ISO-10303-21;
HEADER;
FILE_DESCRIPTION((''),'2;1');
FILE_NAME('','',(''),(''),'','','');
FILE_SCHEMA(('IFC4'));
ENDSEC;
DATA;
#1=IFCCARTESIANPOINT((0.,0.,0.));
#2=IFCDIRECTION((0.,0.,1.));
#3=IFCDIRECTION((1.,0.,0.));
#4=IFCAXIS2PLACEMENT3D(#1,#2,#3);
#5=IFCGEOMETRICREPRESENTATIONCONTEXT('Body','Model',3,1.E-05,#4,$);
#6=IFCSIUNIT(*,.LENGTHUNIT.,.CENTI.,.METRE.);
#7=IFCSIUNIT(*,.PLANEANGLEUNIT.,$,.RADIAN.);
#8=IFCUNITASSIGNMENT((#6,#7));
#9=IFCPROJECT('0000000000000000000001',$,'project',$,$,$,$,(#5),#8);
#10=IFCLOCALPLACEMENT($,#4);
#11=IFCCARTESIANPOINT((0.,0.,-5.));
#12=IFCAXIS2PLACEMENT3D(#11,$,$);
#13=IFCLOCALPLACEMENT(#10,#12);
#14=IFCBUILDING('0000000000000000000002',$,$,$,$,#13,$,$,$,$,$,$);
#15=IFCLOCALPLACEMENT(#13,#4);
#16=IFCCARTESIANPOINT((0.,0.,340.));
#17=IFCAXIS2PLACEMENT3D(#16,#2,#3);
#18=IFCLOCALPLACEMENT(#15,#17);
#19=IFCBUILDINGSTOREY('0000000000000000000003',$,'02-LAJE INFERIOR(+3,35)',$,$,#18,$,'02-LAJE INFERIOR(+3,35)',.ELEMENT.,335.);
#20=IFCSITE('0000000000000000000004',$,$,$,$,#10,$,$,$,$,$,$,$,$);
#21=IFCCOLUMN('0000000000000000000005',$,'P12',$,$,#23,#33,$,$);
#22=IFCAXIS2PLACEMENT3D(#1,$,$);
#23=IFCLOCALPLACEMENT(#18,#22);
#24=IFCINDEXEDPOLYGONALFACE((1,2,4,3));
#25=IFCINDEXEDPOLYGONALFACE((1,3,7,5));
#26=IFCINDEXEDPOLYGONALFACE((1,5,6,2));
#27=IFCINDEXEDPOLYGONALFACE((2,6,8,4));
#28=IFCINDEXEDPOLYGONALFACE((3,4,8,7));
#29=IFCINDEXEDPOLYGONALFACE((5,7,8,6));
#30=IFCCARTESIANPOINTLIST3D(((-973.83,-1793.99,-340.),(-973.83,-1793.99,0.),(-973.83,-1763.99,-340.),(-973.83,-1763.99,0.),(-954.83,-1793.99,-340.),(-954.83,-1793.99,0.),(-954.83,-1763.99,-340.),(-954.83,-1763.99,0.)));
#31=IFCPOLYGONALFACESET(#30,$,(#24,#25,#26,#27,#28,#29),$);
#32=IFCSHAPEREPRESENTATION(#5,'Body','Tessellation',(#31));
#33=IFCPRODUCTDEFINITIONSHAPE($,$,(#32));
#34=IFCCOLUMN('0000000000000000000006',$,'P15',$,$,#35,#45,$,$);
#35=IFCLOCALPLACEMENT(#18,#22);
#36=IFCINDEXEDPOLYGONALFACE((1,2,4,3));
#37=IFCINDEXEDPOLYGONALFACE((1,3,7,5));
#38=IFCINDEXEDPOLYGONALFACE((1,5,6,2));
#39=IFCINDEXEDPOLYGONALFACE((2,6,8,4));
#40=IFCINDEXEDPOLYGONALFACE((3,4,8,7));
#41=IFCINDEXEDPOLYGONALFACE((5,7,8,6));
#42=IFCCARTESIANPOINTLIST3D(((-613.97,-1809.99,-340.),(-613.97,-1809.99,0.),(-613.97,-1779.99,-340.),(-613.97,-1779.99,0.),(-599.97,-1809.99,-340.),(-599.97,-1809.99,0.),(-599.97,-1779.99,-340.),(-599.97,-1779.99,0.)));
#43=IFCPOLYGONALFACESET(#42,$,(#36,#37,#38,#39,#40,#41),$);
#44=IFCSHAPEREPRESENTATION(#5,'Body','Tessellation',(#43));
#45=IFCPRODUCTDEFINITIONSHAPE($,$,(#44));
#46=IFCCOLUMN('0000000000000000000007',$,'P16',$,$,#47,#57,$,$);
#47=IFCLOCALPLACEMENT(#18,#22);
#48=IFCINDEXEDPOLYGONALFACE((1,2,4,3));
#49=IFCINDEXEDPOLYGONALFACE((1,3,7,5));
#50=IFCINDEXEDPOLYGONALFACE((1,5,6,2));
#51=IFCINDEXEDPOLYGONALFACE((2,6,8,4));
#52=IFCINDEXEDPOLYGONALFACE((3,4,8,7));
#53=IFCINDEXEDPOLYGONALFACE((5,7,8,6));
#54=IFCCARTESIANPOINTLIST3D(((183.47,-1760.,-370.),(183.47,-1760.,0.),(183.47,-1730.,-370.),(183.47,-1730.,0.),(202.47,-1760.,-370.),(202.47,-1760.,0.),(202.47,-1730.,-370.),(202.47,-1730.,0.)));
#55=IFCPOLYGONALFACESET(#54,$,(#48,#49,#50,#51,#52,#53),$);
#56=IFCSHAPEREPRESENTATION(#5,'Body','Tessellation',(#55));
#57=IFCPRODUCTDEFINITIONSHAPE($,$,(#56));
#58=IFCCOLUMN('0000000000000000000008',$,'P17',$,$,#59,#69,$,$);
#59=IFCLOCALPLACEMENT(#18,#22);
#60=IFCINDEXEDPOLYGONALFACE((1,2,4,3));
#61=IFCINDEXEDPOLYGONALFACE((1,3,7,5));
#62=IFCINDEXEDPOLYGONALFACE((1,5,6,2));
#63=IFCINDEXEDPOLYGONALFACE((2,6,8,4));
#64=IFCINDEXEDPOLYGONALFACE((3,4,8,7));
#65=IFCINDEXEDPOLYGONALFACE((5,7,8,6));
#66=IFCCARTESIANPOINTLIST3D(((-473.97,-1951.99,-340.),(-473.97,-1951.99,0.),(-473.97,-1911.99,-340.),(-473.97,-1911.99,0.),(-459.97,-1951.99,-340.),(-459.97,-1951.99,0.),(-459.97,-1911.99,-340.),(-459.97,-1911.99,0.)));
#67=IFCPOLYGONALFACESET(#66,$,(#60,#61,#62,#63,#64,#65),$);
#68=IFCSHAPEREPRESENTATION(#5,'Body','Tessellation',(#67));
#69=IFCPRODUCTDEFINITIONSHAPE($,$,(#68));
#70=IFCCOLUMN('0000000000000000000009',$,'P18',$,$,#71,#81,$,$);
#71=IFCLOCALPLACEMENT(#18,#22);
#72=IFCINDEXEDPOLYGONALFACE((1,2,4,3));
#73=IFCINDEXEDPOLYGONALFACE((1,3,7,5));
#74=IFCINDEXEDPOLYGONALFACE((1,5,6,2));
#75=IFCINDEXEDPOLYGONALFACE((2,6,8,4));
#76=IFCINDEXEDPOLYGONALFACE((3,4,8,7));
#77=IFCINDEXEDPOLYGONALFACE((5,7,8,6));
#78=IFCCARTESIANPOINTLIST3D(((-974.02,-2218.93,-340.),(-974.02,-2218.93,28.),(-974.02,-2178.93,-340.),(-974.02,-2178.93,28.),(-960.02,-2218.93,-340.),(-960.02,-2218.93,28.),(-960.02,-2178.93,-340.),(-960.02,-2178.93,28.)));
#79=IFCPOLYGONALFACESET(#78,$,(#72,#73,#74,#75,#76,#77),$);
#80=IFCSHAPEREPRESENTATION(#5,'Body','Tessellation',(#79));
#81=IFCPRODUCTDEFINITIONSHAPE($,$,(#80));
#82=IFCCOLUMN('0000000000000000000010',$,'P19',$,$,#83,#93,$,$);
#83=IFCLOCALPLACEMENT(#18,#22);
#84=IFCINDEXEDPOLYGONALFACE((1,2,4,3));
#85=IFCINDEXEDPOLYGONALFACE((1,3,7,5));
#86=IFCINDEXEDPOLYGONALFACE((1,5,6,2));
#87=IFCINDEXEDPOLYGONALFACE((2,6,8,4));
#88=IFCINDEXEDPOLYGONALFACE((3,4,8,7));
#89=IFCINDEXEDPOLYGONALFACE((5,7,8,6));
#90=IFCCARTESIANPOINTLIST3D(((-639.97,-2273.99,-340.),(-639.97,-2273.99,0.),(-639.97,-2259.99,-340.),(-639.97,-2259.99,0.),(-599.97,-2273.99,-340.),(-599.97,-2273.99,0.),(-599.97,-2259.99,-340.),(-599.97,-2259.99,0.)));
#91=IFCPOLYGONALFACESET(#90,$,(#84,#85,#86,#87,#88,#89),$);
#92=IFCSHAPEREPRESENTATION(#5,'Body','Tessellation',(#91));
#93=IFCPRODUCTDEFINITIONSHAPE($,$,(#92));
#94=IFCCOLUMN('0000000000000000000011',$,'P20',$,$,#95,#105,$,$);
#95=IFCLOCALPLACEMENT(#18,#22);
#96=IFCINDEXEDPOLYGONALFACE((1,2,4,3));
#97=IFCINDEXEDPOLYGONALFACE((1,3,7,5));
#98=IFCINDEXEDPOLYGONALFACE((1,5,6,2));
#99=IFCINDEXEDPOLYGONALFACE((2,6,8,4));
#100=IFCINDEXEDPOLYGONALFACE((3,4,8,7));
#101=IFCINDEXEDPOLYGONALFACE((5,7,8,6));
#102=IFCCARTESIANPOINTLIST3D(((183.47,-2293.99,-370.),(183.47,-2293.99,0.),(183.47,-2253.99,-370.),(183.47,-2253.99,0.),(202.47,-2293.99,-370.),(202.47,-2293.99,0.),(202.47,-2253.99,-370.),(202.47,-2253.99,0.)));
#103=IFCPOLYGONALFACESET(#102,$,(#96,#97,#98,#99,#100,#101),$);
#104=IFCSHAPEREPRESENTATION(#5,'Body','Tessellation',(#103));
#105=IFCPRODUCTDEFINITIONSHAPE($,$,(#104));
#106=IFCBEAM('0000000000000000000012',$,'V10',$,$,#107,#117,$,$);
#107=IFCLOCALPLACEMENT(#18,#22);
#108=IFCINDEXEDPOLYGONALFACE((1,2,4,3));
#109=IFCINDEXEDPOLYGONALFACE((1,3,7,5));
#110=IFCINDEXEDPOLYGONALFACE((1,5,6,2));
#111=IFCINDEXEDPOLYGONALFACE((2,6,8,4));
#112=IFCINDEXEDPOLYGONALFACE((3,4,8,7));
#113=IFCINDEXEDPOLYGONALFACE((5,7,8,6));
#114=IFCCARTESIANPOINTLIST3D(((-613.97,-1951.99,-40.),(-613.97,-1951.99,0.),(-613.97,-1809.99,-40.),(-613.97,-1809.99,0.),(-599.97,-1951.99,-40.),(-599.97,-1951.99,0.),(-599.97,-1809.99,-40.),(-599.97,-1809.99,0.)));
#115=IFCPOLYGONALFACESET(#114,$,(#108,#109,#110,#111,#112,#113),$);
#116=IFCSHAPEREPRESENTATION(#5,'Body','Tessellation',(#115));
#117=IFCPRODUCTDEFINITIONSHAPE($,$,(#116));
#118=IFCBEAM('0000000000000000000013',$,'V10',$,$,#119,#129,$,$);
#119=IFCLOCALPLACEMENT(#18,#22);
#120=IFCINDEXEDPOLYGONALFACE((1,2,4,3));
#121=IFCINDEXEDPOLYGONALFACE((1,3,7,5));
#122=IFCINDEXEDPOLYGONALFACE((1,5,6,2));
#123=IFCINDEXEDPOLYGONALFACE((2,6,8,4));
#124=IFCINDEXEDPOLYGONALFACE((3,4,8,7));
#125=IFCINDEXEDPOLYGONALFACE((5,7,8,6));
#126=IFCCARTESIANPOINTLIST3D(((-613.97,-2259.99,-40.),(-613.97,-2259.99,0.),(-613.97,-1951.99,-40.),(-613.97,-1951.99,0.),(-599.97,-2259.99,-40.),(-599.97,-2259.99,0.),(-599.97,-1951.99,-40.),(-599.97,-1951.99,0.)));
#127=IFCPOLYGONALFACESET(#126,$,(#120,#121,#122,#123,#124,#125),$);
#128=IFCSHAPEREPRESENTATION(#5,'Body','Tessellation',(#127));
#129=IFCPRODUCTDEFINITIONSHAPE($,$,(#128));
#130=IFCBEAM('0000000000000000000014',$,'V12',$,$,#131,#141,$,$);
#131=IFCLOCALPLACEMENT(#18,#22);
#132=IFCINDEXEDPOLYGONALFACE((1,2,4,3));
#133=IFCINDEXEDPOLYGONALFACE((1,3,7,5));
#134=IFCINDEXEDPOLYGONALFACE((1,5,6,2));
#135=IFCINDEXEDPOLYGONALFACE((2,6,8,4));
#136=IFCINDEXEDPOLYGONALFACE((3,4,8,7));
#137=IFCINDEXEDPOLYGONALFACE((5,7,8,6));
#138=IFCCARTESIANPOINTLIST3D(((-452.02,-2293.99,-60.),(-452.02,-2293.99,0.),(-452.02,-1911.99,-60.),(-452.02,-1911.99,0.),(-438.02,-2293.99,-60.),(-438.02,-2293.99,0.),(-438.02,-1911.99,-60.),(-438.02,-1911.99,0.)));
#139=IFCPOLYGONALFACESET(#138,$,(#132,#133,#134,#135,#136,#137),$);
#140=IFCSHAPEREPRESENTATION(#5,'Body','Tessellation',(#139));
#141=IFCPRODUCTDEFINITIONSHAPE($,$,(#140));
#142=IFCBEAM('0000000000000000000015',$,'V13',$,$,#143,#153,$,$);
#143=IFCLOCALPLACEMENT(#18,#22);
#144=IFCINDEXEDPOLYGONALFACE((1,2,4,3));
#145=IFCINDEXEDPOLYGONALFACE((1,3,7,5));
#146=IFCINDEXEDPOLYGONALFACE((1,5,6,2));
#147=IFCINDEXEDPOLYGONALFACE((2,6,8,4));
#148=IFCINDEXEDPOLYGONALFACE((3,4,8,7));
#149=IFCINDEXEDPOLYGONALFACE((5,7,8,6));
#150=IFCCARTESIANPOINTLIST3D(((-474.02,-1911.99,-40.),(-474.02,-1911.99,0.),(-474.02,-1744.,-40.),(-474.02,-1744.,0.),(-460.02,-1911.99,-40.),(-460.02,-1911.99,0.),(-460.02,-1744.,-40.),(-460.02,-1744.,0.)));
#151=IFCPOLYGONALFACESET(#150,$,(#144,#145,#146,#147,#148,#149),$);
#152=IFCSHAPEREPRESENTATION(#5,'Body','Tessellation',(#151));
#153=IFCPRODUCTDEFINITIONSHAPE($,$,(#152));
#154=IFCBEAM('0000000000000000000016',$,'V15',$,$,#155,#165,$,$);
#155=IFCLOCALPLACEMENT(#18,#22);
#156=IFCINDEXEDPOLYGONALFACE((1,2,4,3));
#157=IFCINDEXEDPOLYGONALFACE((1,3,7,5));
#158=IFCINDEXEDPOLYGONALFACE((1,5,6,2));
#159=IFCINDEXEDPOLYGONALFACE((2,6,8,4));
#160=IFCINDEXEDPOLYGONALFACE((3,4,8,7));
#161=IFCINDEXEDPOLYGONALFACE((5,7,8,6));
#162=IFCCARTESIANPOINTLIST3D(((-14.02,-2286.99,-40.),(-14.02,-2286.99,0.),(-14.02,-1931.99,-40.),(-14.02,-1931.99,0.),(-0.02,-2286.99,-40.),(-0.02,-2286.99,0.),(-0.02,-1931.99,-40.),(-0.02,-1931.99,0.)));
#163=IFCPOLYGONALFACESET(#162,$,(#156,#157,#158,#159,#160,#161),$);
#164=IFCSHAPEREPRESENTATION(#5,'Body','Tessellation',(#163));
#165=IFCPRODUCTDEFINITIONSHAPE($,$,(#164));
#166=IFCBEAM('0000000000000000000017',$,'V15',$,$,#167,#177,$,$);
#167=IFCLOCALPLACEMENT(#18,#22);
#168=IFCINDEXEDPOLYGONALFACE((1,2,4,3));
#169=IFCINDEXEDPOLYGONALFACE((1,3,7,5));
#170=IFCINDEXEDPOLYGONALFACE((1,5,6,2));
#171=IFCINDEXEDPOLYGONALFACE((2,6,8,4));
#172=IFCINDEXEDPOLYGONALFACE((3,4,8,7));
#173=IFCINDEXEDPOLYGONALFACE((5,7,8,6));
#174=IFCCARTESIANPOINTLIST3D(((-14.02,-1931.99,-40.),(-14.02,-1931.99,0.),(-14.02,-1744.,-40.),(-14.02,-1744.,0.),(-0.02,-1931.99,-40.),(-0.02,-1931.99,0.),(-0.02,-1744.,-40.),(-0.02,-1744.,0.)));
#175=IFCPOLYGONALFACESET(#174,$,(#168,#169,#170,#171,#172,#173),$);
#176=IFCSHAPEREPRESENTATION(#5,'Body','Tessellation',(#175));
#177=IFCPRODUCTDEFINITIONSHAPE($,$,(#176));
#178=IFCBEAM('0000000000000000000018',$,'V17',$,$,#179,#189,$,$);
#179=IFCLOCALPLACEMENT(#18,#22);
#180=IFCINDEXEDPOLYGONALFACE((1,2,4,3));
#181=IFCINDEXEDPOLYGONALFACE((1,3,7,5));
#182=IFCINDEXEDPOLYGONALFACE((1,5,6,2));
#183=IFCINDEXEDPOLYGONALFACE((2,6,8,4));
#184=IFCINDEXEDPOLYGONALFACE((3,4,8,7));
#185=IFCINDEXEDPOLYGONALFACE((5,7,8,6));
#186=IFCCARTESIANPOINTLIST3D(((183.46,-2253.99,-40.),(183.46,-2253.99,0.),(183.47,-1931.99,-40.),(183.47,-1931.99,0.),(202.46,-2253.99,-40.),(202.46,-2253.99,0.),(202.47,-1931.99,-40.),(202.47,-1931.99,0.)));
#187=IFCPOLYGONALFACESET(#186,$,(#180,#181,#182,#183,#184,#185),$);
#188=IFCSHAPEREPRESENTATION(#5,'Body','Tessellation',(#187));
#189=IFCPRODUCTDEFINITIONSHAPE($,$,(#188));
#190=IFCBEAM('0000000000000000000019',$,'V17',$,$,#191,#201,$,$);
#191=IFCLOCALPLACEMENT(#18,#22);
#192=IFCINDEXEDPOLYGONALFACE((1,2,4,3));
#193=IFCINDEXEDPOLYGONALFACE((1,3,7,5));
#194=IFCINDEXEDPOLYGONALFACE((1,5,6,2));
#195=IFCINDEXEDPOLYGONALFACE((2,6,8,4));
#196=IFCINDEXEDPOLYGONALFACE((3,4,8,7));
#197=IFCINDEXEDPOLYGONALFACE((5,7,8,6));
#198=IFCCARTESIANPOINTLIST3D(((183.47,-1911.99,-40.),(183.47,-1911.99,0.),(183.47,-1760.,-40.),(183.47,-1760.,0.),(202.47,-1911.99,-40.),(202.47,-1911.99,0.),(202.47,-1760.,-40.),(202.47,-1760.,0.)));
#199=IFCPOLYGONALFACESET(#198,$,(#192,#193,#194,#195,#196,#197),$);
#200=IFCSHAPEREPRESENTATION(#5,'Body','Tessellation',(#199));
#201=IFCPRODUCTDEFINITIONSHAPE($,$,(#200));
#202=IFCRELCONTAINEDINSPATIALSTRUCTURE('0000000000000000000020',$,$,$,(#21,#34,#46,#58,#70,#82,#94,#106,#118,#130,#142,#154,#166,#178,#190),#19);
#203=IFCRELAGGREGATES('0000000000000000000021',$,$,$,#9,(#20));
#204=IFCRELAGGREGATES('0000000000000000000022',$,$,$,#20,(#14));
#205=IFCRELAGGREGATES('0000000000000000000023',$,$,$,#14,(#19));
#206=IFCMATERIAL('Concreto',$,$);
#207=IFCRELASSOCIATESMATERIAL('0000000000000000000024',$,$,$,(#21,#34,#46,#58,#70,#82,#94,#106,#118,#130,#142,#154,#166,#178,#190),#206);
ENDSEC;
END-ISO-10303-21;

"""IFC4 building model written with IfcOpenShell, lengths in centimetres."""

from ifc_helpers import new_model, si_unit, frame, origin_with_axes, origin_2d_with_axis, place, context, project, spatial, rectangle, extrude, material, element, save


model = new_model("IFC4")

# Units and contexts
model_context = context("Model", 3, precision=1e-05, world=origin_with_axes(), identifier="Body")
ifc_project = project(units=[si_unit("LENGTHUNIT", "METRE", prefix="CENTI"), si_unit("PLANEANGLEUNIT", "RADIAN")], contexts=[model_context])

# Site, building, storey
site_placement = place(None, origin_with_axes())
site = spatial("IfcSite", under=ifc_project, at=site_placement)
building_placement = place(site_placement, frame((0.0, 0.0, -5.0)))
building = spatial("IfcBuilding", under=site, at=building_placement)
placement = place(building_placement, origin_with_axes())
storey_placement = place(placement, frame((0.0, 0.0, 340.0), z_axis=(0.0, 0.0, 1.0), x_axis=(1.0, 0.0, 0.0)))
storey = spatial("IfcBuildingStorey", under=building, at=storey_placement, Name="02-LAJE INFERIOR(+3,35)", LongName="02-LAJE INFERIOR(+3,35)", CompositionType="ELEMENT", Elevation=335.0)

# Columns
ifc_material = material(Name="Concreto")
column_1_placement = place(storey_placement, frame((-964.33, -1778.99, 0.0), z_axis=(0.0, 0.0, 1.0), x_axis=(1.0, 0.0, 0.0)))
element("IfcColumn", 1, at=column_1_placement, inside=storey, material=ifc_material, Name="P12", context=model_context, shape_type="SolidModel", body=[
    extrude(rectangle(XDim=19.0, YDim=30.0, at=origin_2d_with_axis()), origin_with_axes(), (0.0, 0.0, -1.0), 340.0),
])
column_2_placement = place(storey_placement, frame((-606.97, -1794.99, 0.0), z_axis=(0.0, 0.0, 1.0), x_axis=(1.0, 0.0, 0.0)))
element("IfcColumn", 2, at=column_2_placement, inside=storey, material=ifc_material, Name="P15", context=model_context, shape_type="SolidModel", body=[
    extrude(rectangle(XDim=14.0, YDim=30.0, at=origin_2d_with_axis()), origin_with_axes(), (0.0, 0.0, -1.0), 340.0),
])
column_3_placement = place(storey_placement, frame((192.97, -1745.0, 0.0), z_axis=(0.0, 0.0, 1.0), x_axis=(1.0, 0.0, 0.0)))
element("IfcColumn", 3, at=column_3_placement, inside=storey, material=ifc_material, Name="P16", context=model_context, shape_type="SolidModel", body=[
    extrude(rectangle(XDim=19.0, YDim=30.0, at=origin_2d_with_axis()), frame((0.0, 0.0, 0.0), z_axis=(0.0, 0.0, 1.0), x_axis=(-1.0, 0.0, 0.0)), (0.0, 0.0, -1.0), 370.0),
])
column_4_placement = place(storey_placement, frame((-466.97, -1931.99, 0.0), z_axis=(0.0, 0.0, 1.0), x_axis=(1.0, 0.0, 0.0)))
element("IfcColumn", 4, at=column_4_placement, inside=storey, material=ifc_material, Name="P17", context=model_context, shape_type="SolidModel", body=[
    extrude(rectangle(XDim=14.0, YDim=40.0, at=origin_2d_with_axis()), origin_with_axes(), (0.0, 0.0, -1.0), 340.0),
])
column_5_placement = place(storey_placement, frame((-967.02, -2198.93, 28.0), z_axis=(0.0, 0.0, 1.0), x_axis=(1.0, 0.0, 0.0)))
element("IfcColumn", 5, at=column_5_placement, inside=storey, material=ifc_material, Name="P18", context=model_context, shape_type="SolidModel", body=[
    extrude(rectangle(XDim=14.0, YDim=40.0, at=origin_2d_with_axis()), origin_with_axes(), (0.0, 0.0, -1.0), 368.0),
])
column_6_placement = place(storey_placement, frame((-619.97, -2266.99, 0.0), z_axis=(0.0, 0.0, 1.0), x_axis=(1.0, 0.0, 0.0)))
element("IfcColumn", 6, at=column_6_placement, inside=storey, material=ifc_material, Name="P19", context=model_context, shape_type="SolidModel", body=[
    extrude(rectangle(XDim=14.0, YDim=40.0, at=origin_2d_with_axis()), frame((0.0, 0.0, 0.0), z_axis=(0.0, 0.0, 1.0), x_axis=(0.0, 1.0, 0.0)), (0.0, 0.0, -1.0), 340.0),
])
column_7_placement = place(storey_placement, frame((192.97, -2273.99, 0.0), z_axis=(0.0, 0.0, 1.0), x_axis=(1.0, 0.0, 0.0)))
element("IfcColumn", 7, at=column_7_placement, inside=storey, material=ifc_material, Name="P20", context=model_context, shape_type="SolidModel", body=[
    extrude(rectangle(XDim=19.0, YDim=40.0, at=origin_2d_with_axis()), origin_with_axes(), (0.0, 0.0, -1.0), 370.0),
])

# Beams
beam_1_placement = place(storey_placement, frame((-606.97, -1880.99, 0.0), z_axis=(0.0, 0.0, 1.0), x_axis=(1.0, 0.0, 0.0)))
element("IfcBeam", 8, at=beam_1_placement, inside=storey, material=ifc_material, Name="V10", context=model_context, shape_type="SolidModel", body=[
    extrude(rectangle(XDim=14.0, YDim=40.0, at=origin_2d_with_axis()), frame((0.0, -71.0, -20.0), z_axis=(0.0, 1.0, 0.0), x_axis=(1.0, 0.0, 0.0)), (0.0, 0.0, 1.0), 142.0),
])
beam_2_placement = place(storey_placement, frame((-606.97, -2105.99, 0.0), z_axis=(0.0, 0.0, 1.0), x_axis=(1.0, 0.0, 0.0)))
element("IfcBeam", 9, at=beam_2_placement, inside=storey, material=ifc_material, Name="V10", context=model_context, shape_type="SolidModel", body=[
    extrude(rectangle(XDim=14.0, YDim=40.0, at=origin_2d_with_axis()), frame((0.0, -154.0, -20.0), z_axis=(0.0, 1.0, 0.0), x_axis=(1.0, 0.0, 0.0)), (0.0, 0.0, 1.0), 308.0),
])
beam_3_placement = place(storey_placement, frame((-445.02, -2102.99, 0.0), z_axis=(0.0, 0.0, 1.0), x_axis=(1.0, 0.0, 0.0)))
element("IfcBeam", 10, at=beam_3_placement, inside=storey, material=ifc_material, Name="V12", context=model_context, shape_type="SolidModel", body=[
    extrude(rectangle(XDim=14.0, YDim=60.0, at=origin_2d_with_axis()), frame((0.0, -191.0, -30.0), z_axis=(0.0, 1.0, 0.0), x_axis=(1.0, 0.0, 0.0)), (0.0, 0.0, 1.0), 382.0),
])
beam_4_placement = place(storey_placement, frame((-467.02, -1827.99, 0.0), z_axis=(0.0, 0.0, 1.0), x_axis=(1.0, 0.0, 0.0)))
element("IfcBeam", 11, at=beam_4_placement, inside=storey, material=ifc_material, Name="V13", context=model_context, shape_type="SolidModel", body=[
    extrude(rectangle(XDim=14.0, YDim=40.0, at=origin_2d_with_axis()), frame((0.0, -84.0, -20.0), z_axis=(0.0, 1.0, 0.0), x_axis=(1.0, 0.0, 0.0)), (0.0, 0.0, 1.0), 167.99),
])
beam_5_placement = place(storey_placement, frame((-7.02, -2109.49, 0.0), z_axis=(0.0, 0.0, 1.0), x_axis=(1.0, 0.0, 0.0)))
element("IfcBeam", 12, at=beam_5_placement, inside=storey, material=ifc_material, Name="V15", context=model_context, shape_type="SolidModel", body=[
    extrude(rectangle(XDim=14.0, YDim=40.0, at=origin_2d_with_axis()), frame((0.0, -177.5, -20.0), z_axis=(0.0, 1.0, 0.0), x_axis=(1.0, 0.0, 0.0)), (0.0, 0.0, 1.0), 355.0),
])
beam_6_placement = place(storey_placement, frame((-7.02, -1837.99, 0.0), z_axis=(0.0, 0.0, 1.0), x_axis=(1.0, 0.0, 0.0)))
element("IfcBeam", 13, at=beam_6_placement, inside=storey, material=ifc_material, Name="V15", context=model_context, shape_type="SolidModel", body=[
    extrude(rectangle(XDim=14.0, YDim=40.0, at=origin_2d_with_axis()), frame((0.0, -94.0, -20.0), z_axis=(0.0, 1.0, 0.0), x_axis=(1.0, 0.0, 0.0)), (0.0, 0.0, 1.0), 187.99),
])
beam_7_placement = place(storey_placement, frame((192.97, -2092.99, 0.0), z_axis=(0.0, 0.0, 1.0), x_axis=(1.0, 0.0, 0.0)))
element("IfcBeam", 14, at=beam_7_placement, inside=storey, material=ifc_material, Name="V17", context=model_context, shape_type="SolidModel", body=[
    extrude(rectangle(XDim=19.0, YDim=40.0, at=origin_2d_with_axis()), frame((-0.01, -161.0, -20.0), z_axis=(0.000031, 1.0, 0.0), x_axis=(1.0, -0.000031, 0.0)), (0.0, 0.0, 1.0), 322.0),
])
beam_8_placement = place(storey_placement, frame((192.97, -1835.99, 0.0), z_axis=(0.0, 0.0, 1.0), x_axis=(1.0, 0.0, 0.0)))
element("IfcBeam", 15, at=beam_8_placement, inside=storey, material=ifc_material, Name="V17", context=model_context, shape_type="SolidModel", body=[
    extrude(rectangle(XDim=19.0, YDim=40.0, at=origin_2d_with_axis()), frame((0.0, -76.0, -20.0), z_axis=(0.0, 1.0, 0.0), x_axis=(1.0, 0.0, 0.0)), (0.0, 0.0, 1.0), 151.99),
])

save(model, "model.ifc")
